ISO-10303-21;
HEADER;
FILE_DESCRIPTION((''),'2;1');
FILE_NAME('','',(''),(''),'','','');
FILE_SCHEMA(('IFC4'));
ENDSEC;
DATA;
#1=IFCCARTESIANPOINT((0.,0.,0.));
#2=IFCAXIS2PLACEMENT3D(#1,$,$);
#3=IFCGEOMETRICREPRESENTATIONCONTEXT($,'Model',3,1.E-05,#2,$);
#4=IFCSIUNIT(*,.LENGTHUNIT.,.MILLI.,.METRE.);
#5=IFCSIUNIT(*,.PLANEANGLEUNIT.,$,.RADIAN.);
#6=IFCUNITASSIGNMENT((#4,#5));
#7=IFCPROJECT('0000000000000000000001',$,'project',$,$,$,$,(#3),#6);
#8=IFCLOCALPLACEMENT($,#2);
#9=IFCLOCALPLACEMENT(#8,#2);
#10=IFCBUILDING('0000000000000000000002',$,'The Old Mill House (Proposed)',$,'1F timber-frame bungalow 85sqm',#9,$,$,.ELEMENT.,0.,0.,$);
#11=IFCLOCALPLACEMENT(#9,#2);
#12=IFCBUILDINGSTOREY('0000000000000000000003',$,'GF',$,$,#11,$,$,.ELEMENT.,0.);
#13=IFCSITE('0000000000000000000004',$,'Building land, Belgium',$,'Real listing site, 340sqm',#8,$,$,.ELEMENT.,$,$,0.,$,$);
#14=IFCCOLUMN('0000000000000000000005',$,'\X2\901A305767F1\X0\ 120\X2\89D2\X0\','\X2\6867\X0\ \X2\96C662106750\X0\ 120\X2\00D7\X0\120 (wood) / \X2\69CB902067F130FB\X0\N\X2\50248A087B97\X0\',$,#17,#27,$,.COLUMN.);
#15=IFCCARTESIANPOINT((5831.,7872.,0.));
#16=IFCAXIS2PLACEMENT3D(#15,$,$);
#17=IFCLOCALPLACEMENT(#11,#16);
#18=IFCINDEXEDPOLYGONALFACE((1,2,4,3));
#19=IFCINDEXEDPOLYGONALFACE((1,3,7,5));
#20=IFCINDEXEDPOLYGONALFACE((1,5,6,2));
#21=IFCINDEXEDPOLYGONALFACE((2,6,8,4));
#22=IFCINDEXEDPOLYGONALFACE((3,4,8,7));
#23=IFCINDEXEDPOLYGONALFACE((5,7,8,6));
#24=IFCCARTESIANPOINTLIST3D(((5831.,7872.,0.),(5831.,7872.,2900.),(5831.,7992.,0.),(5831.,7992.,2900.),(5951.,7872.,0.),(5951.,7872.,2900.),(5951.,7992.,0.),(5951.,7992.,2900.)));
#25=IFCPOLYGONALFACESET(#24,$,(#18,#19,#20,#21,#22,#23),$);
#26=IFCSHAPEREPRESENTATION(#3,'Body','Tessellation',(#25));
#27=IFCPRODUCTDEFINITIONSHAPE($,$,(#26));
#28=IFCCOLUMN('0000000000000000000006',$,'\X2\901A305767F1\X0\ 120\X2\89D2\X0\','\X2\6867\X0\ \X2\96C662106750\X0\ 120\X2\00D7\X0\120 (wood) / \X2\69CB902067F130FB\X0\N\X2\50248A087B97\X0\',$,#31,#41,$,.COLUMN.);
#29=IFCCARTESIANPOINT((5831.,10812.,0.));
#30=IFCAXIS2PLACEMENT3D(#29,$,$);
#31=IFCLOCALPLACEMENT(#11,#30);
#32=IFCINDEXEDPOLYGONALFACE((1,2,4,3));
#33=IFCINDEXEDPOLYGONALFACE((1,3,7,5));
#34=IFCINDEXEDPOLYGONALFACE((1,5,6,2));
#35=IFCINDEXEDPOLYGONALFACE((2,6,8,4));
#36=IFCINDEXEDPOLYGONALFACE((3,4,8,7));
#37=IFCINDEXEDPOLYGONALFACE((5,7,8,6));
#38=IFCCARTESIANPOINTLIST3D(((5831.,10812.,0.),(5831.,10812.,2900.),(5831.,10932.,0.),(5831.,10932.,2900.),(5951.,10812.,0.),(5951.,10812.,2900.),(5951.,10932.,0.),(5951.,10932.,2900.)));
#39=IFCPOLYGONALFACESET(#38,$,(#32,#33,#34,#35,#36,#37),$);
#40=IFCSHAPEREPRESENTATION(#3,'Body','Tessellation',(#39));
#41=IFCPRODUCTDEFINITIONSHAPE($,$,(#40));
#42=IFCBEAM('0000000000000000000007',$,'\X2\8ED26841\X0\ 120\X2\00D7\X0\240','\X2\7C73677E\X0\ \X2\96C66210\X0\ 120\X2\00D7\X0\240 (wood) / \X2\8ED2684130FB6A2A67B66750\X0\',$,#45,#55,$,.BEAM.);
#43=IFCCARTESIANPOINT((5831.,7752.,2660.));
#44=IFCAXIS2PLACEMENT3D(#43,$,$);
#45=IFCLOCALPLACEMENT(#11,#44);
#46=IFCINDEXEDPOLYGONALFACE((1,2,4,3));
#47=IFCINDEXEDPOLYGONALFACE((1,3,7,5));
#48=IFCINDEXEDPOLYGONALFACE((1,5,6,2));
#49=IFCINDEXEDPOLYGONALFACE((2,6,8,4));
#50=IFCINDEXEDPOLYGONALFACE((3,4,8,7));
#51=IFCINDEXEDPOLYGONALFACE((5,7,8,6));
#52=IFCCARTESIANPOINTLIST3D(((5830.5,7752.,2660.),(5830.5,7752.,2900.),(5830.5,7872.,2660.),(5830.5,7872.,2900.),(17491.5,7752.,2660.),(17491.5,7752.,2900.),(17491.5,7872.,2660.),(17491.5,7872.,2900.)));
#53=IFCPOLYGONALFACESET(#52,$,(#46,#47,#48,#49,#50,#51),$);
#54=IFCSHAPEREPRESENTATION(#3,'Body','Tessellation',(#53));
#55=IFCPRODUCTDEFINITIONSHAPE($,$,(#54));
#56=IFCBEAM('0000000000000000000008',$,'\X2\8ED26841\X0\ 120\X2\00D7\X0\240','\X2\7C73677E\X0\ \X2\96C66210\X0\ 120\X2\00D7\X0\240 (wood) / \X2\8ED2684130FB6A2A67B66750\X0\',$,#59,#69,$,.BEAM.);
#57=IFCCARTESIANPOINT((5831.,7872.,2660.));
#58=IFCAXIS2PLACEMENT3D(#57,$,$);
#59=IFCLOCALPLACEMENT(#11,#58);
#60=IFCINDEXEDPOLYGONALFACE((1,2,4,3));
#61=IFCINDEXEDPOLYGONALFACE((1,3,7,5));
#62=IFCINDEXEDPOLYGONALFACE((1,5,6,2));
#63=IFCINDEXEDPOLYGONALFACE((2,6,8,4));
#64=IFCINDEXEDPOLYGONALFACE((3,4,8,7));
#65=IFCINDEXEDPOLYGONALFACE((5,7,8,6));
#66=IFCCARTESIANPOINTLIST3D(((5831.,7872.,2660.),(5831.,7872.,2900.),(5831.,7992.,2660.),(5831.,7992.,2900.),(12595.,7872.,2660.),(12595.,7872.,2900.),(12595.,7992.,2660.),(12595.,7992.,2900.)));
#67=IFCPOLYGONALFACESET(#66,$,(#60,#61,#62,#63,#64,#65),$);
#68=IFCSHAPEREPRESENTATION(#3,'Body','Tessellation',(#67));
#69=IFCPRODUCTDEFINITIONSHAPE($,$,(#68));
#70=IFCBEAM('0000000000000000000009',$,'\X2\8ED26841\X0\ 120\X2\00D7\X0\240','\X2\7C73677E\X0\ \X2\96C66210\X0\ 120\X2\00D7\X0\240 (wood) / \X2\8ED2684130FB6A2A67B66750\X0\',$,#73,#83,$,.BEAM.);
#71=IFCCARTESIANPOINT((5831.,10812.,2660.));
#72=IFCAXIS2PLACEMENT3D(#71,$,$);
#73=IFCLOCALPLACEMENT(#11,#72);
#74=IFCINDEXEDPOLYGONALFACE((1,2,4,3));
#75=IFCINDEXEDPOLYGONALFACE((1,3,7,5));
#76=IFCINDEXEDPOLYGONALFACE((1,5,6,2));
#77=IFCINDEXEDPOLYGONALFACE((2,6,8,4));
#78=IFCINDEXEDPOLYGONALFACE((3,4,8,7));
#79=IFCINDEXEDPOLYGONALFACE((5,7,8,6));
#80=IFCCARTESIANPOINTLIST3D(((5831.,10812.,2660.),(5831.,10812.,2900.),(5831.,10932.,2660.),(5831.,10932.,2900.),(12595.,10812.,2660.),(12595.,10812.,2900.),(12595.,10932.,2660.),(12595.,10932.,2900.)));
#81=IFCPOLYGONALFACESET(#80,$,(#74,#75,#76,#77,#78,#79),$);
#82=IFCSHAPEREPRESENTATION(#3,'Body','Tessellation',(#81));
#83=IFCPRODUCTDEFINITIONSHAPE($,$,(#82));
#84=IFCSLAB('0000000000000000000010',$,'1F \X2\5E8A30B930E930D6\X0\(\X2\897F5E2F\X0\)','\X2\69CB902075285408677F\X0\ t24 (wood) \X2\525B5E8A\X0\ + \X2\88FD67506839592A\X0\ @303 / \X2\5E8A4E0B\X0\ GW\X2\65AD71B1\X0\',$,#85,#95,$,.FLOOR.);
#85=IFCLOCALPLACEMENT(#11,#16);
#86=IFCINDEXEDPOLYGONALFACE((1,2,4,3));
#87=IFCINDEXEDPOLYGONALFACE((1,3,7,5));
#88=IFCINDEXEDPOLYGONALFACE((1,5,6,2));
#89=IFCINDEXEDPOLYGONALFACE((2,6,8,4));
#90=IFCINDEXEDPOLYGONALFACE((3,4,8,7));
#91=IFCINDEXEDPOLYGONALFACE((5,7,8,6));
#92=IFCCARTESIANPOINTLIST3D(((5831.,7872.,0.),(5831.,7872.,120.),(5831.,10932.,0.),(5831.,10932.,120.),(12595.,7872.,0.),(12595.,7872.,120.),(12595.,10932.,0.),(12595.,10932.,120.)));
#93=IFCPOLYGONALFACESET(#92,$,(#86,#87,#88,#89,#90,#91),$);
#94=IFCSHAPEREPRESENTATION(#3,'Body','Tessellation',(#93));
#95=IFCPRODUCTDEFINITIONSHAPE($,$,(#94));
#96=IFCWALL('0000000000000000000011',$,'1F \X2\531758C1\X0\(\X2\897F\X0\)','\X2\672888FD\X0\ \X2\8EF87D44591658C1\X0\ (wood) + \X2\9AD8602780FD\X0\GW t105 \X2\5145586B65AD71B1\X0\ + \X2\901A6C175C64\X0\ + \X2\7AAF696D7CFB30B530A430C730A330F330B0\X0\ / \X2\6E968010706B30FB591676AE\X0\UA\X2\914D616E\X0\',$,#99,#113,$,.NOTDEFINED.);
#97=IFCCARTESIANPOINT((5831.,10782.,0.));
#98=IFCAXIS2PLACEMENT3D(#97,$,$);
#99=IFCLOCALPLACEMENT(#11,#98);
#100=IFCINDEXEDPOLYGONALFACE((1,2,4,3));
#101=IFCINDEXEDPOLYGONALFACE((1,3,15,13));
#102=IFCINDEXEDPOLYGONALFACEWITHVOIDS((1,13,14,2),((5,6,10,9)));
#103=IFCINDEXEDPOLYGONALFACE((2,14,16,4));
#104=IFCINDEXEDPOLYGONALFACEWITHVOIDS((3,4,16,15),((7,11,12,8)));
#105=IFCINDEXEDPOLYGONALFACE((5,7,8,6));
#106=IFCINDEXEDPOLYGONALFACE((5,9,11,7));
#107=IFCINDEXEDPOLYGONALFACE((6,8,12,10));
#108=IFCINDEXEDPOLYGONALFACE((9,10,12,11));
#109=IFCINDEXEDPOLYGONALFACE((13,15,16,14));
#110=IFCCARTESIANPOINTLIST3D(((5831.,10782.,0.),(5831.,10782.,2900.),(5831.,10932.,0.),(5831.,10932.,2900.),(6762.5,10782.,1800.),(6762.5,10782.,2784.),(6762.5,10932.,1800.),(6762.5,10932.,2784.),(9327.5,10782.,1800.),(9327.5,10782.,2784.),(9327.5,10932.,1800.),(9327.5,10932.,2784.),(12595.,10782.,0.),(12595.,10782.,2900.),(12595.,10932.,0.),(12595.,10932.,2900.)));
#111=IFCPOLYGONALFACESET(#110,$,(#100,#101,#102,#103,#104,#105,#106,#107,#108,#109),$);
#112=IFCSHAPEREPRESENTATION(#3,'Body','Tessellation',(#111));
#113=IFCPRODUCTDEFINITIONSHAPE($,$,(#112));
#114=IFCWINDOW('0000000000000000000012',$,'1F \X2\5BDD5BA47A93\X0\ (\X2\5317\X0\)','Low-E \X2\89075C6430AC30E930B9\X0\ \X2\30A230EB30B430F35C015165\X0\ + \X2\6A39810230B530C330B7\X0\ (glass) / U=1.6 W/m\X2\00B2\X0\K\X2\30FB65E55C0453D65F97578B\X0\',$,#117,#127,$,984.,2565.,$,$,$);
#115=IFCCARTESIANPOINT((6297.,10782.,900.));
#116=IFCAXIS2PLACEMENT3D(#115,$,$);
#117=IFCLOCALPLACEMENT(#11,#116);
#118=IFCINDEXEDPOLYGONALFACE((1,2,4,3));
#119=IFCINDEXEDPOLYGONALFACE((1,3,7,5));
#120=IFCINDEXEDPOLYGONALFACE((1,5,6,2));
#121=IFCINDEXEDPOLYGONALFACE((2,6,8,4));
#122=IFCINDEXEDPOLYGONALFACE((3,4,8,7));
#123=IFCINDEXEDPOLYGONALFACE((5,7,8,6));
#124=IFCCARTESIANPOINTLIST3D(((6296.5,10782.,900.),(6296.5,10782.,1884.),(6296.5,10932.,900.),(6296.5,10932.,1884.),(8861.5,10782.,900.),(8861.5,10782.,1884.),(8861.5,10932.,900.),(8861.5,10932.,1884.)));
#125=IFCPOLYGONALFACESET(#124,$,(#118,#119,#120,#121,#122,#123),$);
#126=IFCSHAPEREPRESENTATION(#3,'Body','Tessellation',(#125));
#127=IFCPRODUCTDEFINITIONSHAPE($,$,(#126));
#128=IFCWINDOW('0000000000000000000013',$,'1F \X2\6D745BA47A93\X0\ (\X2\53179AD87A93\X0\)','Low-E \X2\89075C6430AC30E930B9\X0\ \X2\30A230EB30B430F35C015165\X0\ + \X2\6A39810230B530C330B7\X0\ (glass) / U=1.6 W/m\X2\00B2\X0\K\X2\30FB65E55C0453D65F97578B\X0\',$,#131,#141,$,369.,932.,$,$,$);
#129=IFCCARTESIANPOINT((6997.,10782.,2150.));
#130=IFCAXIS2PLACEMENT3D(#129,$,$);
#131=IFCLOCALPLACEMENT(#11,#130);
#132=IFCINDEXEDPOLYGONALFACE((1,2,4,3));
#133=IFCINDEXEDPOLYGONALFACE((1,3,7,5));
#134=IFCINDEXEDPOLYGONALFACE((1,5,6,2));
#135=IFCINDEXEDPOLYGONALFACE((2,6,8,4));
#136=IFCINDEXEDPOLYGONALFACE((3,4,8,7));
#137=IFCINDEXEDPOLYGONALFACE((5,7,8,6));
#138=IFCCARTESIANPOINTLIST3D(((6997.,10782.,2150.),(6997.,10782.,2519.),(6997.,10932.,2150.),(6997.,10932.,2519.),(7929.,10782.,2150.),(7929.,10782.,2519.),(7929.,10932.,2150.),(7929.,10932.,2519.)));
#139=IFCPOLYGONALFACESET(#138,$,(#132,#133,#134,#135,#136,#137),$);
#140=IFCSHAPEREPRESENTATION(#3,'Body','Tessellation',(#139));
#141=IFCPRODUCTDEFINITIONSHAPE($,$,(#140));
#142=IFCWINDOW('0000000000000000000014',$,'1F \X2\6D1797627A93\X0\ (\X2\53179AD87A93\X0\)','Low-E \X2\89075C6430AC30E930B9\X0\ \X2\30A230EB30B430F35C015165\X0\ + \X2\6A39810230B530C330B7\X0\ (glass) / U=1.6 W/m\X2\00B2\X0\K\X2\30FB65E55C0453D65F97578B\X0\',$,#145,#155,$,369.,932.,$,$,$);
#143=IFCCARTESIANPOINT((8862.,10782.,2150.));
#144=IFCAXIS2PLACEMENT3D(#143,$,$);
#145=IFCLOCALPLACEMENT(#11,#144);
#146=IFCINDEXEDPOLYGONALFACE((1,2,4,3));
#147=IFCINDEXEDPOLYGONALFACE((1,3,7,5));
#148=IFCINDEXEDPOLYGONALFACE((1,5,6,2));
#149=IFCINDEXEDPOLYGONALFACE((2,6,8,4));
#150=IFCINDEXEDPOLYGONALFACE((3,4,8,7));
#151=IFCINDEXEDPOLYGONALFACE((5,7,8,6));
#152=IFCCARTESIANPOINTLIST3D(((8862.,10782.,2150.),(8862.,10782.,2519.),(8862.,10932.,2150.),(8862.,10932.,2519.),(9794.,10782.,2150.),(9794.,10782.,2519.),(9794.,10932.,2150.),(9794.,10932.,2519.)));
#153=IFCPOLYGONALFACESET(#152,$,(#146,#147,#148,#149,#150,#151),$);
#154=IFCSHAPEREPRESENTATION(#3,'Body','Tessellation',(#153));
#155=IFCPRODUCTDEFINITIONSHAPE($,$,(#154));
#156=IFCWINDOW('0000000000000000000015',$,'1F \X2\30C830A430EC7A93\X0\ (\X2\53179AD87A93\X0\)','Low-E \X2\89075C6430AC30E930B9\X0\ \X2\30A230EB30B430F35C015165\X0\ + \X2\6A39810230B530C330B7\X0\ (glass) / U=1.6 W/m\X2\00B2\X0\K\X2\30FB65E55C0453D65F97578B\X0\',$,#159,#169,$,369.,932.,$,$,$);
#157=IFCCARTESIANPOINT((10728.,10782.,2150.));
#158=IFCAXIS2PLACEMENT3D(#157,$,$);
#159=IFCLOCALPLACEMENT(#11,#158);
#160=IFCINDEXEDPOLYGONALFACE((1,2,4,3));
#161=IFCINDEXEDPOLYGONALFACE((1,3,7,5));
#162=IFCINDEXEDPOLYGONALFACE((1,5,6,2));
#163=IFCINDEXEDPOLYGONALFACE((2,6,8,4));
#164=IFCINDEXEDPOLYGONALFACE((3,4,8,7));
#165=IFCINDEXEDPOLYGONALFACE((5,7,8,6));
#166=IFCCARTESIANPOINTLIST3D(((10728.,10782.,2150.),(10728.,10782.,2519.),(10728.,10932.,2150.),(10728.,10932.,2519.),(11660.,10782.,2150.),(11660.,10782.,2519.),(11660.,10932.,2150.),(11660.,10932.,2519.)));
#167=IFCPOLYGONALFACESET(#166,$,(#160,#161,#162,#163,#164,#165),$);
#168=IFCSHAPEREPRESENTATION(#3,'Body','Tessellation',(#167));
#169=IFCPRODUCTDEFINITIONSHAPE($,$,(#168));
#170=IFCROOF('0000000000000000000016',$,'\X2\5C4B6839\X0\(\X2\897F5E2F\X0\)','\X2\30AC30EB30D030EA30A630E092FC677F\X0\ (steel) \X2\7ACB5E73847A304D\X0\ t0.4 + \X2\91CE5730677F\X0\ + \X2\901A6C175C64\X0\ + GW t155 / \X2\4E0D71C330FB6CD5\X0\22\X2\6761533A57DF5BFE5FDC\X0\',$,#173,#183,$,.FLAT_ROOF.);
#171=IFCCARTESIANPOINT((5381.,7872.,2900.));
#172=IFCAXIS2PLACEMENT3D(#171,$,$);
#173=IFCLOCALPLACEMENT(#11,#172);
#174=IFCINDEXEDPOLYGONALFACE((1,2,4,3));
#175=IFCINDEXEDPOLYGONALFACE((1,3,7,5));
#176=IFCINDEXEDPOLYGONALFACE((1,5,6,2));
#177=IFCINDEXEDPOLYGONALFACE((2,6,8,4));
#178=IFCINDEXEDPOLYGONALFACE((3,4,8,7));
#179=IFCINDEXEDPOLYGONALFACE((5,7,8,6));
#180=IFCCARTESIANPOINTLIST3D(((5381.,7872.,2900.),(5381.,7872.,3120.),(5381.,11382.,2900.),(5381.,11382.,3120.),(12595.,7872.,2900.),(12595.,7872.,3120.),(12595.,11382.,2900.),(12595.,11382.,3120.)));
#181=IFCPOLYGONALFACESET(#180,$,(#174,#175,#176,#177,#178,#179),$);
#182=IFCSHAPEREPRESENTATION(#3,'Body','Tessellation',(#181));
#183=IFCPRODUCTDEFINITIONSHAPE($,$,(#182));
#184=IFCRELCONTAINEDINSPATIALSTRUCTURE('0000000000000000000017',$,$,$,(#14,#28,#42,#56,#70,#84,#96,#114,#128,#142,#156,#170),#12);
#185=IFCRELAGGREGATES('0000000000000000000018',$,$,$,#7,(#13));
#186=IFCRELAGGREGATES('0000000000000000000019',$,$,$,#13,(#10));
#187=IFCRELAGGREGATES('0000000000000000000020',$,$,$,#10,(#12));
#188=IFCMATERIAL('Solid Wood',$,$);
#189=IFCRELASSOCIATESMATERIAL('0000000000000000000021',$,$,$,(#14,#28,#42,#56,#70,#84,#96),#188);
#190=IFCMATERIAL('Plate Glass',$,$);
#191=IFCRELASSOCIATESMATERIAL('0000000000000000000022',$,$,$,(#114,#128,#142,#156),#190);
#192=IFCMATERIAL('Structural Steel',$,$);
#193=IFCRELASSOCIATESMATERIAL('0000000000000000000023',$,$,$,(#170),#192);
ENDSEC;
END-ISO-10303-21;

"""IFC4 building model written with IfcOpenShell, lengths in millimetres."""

from ifc_helpers import new_model, si_unit, frame, frame_2d, origin, place, context, project, spatial, rectangle, extrude, material, element, fill, save


model = new_model("IFC4")

# Units and contexts
model_context = context("Model", 3, precision=1e-05, world=origin())
ifc_project = project(units=[si_unit("LENGTHUNIT", "METRE", prefix="MILLI"), si_unit("PLANEANGLEUNIT", "RADIAN")], contexts=[model_context])

# Site, building, storey
site_placement = place(None, origin())
site = spatial("IfcSite", under=ifc_project, at=site_placement, Name="Building land, Belgium", ObjectType="Real listing site, 340sqm", CompositionType="ELEMENT", RefElevation=0.0)
building_placement = place(site_placement, origin())
building = spatial("IfcBuilding", under=site, at=building_placement, Name="The Old Mill House (Proposed)", ObjectType="1F timber-frame bungalow 85sqm", CompositionType="ELEMENT", ElevationOfRefHeight=0.0, ElevationOfTerrain=0.0)
storey_placement = place(building_placement, origin())
storey = spatial("IfcBuildingStorey", under=building, at=storey_placement, Name="GF", CompositionType="ELEMENT", Elevation=0.0)

# Columns
ifc_material_1 = material(Name="Solid Wood")
column_1_placement = place(storey_placement, frame((5831.0, 7872.0, 0.0)))
element("IfcColumn", 1, at=column_1_placement, inside=storey, material=ifc_material_1, Name="通し柱 120角", Description="桧 集成材 120×120 (wood) / 構造柱・N値計算", PredefinedType="COLUMN", context=model_context, shape_type="SweptSolid", body=[
    extrude(rectangle(XDim=120.0, YDim=120.0, at=frame_2d((60.0, 60.0))), frame((5831.0, 7872.0, 0.0)), (0.0, 0.0, 1.0), 2900.0),
])
column_2_placement = place(storey_placement, frame((5831.0, 10812.0, 0.0)))
element("IfcColumn", 2, at=column_2_placement, inside=storey, material=ifc_material_1, Name="通し柱 120角", Description="桧 集成材 120×120 (wood) / 構造柱・N値計算", PredefinedType="COLUMN", context=model_context, shape_type="SweptSolid", body=[
    extrude(rectangle(XDim=120.0, YDim=120.0, at=frame_2d((60.0, 60.0))), frame((5831.0, 10812.0, 0.0)), (0.0, 0.0, 1.0), 2900.0),
])

# Beams
beam_1_placement = place(storey_placement, frame((5831.0, 7752.0, 2660.0)))
element("IfcBeam", 3, at=beam_1_placement, inside=storey, material=ifc_material_1, Name="軒桁 120×240", Description="米松 集成 120×240 (wood) / 軒桁・横架材", PredefinedType="BEAM", context=model_context, shape_type="SweptSolid", body=[
    extrude(rectangle(XDim=11661.0, YDim=120.0, at=frame_2d((5830.0, 60.0))), frame((5831.0, 7752.0, 2660.0)), (0.0, 0.0, 1.0), 240.0),
])
beam_2_placement = place(storey_placement, frame((5831.0, 7872.0, 2660.0)))
element("IfcBeam", 4, at=beam_2_placement, inside=storey, material=ifc_material_1, Name="軒桁 120×240", Description="米松 集成 120×240 (wood) / 軒桁・横架材", PredefinedType="BEAM", context=model_context, shape_type="SweptSolid", body=[
    extrude(rectangle(XDim=6764.0, YDim=120.0, at=frame_2d((3382.0, 60.0))), frame((5831.0, 7872.0, 2660.0)), (0.0, 0.0, 1.0), 240.0),
])
beam_3_placement = place(storey_placement, frame((5831.0, 10812.0, 2660.0)))
element("IfcBeam", 5, at=beam_3_placement, inside=storey, material=ifc_material_1, Name="軒桁 120×240", Description="米松 集成 120×240 (wood) / 軒桁・横架材", PredefinedType="BEAM", context=model_context, shape_type="SweptSolid", body=[
    extrude(rectangle(XDim=6764.0, YDim=120.0, at=frame_2d((3382.0, 60.0))), frame((5831.0, 10812.0, 2660.0)), (0.0, 0.0, 1.0), 240.0),
])

# Slab
slab_placement = place(storey_placement, frame((5831.0, 7872.0, 0.0)))
element("IfcSlab", 6, at=slab_placement, inside=storey, material=ifc_material_1, Name="1F 床スラブ(西帯)", Description="構造用合板 t24 (wood) 剛床 + 製材根太 @303 / 床下 GW断熱", PredefinedType="FLOOR", context=model_context, shape_type="SweptSolid", body=[
    extrude(rectangle(XDim=6764.0, YDim=3060.0, at=frame_2d((3382.0, 1530.0))), frame((5831.0, 7872.0, 0.0)), (0.0, 0.0, 1.0), 120.0),
])

# Wall, openings, windows
wall_1_placement = place(storey_placement, frame((5831.0, 10782.0, 0.0)))
wall_1 = element("IfcWall", 7, at=wall_1_placement, inside=storey, material=ifc_material_1, Name="1F 北壁(西)", Description="木製 軸組外壁 (wood) + 高性能GW t105 充填断熱 + 通気層 + 窯業系サイディング / 準耐火・外皮UA配慮", PredefinedType="NOTDEFINED", context=model_context, shape_type="SweptSolid", body=[
    extrude(rectangle(XDim=6764.0, YDim=150.0, at=frame_2d((3382.0, 75.0))), frame((5831.0, 10782.0, 0.0)), (0.0, 0.0, 1.0), 2900.0),
])
opening_1_placement = place(storey_placement, frame((6297.0, 10782.0, 900.0)))
opening_1 = element("IfcOpeningElement", 8, at=opening_1_placement, cuts=wall_1, PredefinedType="NOTDEFINED", context=model_context, shape_type="SweptSolid", body=[
    extrude(rectangle(XDim=2565.0, YDim=150.0, at=frame_2d((1282.0, 75.0))), frame((6297.0, 10782.0, 900.0)), (0.0, 0.0, 1.0), 984.0),
])
opening_2_placement = place(storey_placement, frame((6997.0, 10782.0, 2150.0)))
opening_2 = element("IfcOpeningElement", 9, at=opening_2_placement, cuts=wall_1, PredefinedType="NOTDEFINED", context=model_context, shape_type="SweptSolid", body=[
    extrude(rectangle(XDim=932.0, YDim=150.0, at=frame_2d((466.0, 75.0))), frame((6997.0, 10782.0, 2150.0)), (0.0, 0.0, 1.0), 369.0),
])
opening_3_placement = place(storey_placement, frame((8862.0, 10782.0, 2150.0)))
opening_3 = element("IfcOpeningElement", 10, at=opening_3_placement, cuts=wall_1, PredefinedType="NOTDEFINED", context=model_context, shape_type="SweptSolid", body=[
    extrude(rectangle(XDim=932.0, YDim=150.0, at=frame_2d((466.0, 75.0))), frame((8862.0, 10782.0, 2150.0)), (0.0, 0.0, 1.0), 369.0),
])
opening_4_placement = place(storey_placement, frame((10728.0, 10782.0, 2150.0)))
opening_4 = element("IfcOpeningElement", 11, at=opening_4_placement, cuts=wall_1, PredefinedType="NOTDEFINED", context=model_context, shape_type="SweptSolid", body=[
    extrude(rectangle(XDim=932.0, YDim=150.0, at=frame_2d((466.0, 75.0))), frame((10728.0, 10782.0, 2150.0)), (0.0, 0.0, 1.0), 369.0),
])
ifc_material_2 = material(Name="Plate Glass")
window_1_placement = place(storey_placement, frame((6297.0, 10782.0, 900.0)))
window_1 = element("IfcWindow", 12, at=window_1_placement, inside=storey, material=ifc_material_2, Name="1F 寝室窓 (北)", Description="Low-E 複層ガラス アルゴン封入 + 樹脂サッシ (glass) / U=1.6 W/m²K・日射取得型", OverallHeight=984.0, OverallWidth=2565.0, context=model_context, shape_type="SweptSolid", body=[
    extrude(rectangle(XDim=2565.0, YDim=150.0, at=frame_2d((1282.0, 75.0))), frame((6297.0, 10782.0, 900.0)), (0.0, 0.0, 1.0), 984.0),
])
fill(opening_1, window_1)
window_2_placement = place(storey_placement, frame((6997.0, 10782.0, 2150.0)))
window_2 = element("IfcWindow", 13, at=window_2_placement, inside=storey, material=ifc_material_2, Name="1F 浴室窓 (北高窓)", Description="Low-E 複層ガラス アルゴン封入 + 樹脂サッシ (glass) / U=1.6 W/m²K・日射取得型", OverallHeight=369.0, OverallWidth=932.0, context=model_context, shape_type="SweptSolid", body=[
    extrude(rectangle(XDim=932.0, YDim=150.0, at=frame_2d((466.0, 75.0))), frame((6997.0, 10782.0, 2150.0)), (0.0, 0.0, 1.0), 369.0),
])
fill(opening_2, window_2)
window_3_placement = place(storey_placement, frame((8862.0, 10782.0, 2150.0)))
window_3 = element("IfcWindow", 14, at=window_3_placement, inside=storey, material=ifc_material_2, Name="1F 洗面窓 (北高窓)", Description="Low-E 複層ガラス アルゴン封入 + 樹脂サッシ (glass) / U=1.6 W/m²K・日射取得型", OverallHeight=369.0, OverallWidth=932.0, context=model_context, shape_type="SweptSolid", body=[
    extrude(rectangle(XDim=932.0, YDim=150.0, at=frame_2d((466.0, 75.0))), frame((8862.0, 10782.0, 2150.0)), (0.0, 0.0, 1.0), 369.0),
])
fill(opening_3, window_3)
window_4_placement = place(storey_placement, frame((10728.0, 10782.0, 2150.0)))
window_4 = element("IfcWindow", 15, at=window_4_placement, inside=storey, material=ifc_material_2, Name="1F トイレ窓 (北高窓)", Description="Low-E 複層ガラス アルゴン封入 + 樹脂サッシ (glass) / U=1.6 W/m²K・日射取得型", OverallHeight=369.0, OverallWidth=932.0, context=model_context, shape_type="SweptSolid", body=[
    extrude(rectangle(XDim=932.0, YDim=150.0, at=frame_2d((466.0, 75.0))), frame((10728.0, 10782.0, 2150.0)), (0.0, 0.0, 1.0), 369.0),
])
fill(opening_4, window_4)

# Roof
ifc_material_3 = material(Name="Structural Steel")
roof_placement = place(storey_placement, frame((5381.0, 7872.0, 2900.0)))
element("IfcRoof", 16, at=roof_placement, inside=storey, material=ifc_material_3, Name="屋根(西帯)", Description="ガルバリウム鋼板 (steel) 立平葺き t0.4 + 野地板 + 通気層 + GW t155 / 不燃・法22条区域対応", PredefinedType="FLAT_ROOF", context=model_context, shape_type="SweptSolid", body=[
    extrude(rectangle(XDim=7214.0, YDim=3510.0, at=frame_2d((3607.0, 1755.0))), frame((5381.0, 7872.0, 2900.0)), (0.0, 0.0, 1.0), 220.0),
])

save(model, "model.ifc")
